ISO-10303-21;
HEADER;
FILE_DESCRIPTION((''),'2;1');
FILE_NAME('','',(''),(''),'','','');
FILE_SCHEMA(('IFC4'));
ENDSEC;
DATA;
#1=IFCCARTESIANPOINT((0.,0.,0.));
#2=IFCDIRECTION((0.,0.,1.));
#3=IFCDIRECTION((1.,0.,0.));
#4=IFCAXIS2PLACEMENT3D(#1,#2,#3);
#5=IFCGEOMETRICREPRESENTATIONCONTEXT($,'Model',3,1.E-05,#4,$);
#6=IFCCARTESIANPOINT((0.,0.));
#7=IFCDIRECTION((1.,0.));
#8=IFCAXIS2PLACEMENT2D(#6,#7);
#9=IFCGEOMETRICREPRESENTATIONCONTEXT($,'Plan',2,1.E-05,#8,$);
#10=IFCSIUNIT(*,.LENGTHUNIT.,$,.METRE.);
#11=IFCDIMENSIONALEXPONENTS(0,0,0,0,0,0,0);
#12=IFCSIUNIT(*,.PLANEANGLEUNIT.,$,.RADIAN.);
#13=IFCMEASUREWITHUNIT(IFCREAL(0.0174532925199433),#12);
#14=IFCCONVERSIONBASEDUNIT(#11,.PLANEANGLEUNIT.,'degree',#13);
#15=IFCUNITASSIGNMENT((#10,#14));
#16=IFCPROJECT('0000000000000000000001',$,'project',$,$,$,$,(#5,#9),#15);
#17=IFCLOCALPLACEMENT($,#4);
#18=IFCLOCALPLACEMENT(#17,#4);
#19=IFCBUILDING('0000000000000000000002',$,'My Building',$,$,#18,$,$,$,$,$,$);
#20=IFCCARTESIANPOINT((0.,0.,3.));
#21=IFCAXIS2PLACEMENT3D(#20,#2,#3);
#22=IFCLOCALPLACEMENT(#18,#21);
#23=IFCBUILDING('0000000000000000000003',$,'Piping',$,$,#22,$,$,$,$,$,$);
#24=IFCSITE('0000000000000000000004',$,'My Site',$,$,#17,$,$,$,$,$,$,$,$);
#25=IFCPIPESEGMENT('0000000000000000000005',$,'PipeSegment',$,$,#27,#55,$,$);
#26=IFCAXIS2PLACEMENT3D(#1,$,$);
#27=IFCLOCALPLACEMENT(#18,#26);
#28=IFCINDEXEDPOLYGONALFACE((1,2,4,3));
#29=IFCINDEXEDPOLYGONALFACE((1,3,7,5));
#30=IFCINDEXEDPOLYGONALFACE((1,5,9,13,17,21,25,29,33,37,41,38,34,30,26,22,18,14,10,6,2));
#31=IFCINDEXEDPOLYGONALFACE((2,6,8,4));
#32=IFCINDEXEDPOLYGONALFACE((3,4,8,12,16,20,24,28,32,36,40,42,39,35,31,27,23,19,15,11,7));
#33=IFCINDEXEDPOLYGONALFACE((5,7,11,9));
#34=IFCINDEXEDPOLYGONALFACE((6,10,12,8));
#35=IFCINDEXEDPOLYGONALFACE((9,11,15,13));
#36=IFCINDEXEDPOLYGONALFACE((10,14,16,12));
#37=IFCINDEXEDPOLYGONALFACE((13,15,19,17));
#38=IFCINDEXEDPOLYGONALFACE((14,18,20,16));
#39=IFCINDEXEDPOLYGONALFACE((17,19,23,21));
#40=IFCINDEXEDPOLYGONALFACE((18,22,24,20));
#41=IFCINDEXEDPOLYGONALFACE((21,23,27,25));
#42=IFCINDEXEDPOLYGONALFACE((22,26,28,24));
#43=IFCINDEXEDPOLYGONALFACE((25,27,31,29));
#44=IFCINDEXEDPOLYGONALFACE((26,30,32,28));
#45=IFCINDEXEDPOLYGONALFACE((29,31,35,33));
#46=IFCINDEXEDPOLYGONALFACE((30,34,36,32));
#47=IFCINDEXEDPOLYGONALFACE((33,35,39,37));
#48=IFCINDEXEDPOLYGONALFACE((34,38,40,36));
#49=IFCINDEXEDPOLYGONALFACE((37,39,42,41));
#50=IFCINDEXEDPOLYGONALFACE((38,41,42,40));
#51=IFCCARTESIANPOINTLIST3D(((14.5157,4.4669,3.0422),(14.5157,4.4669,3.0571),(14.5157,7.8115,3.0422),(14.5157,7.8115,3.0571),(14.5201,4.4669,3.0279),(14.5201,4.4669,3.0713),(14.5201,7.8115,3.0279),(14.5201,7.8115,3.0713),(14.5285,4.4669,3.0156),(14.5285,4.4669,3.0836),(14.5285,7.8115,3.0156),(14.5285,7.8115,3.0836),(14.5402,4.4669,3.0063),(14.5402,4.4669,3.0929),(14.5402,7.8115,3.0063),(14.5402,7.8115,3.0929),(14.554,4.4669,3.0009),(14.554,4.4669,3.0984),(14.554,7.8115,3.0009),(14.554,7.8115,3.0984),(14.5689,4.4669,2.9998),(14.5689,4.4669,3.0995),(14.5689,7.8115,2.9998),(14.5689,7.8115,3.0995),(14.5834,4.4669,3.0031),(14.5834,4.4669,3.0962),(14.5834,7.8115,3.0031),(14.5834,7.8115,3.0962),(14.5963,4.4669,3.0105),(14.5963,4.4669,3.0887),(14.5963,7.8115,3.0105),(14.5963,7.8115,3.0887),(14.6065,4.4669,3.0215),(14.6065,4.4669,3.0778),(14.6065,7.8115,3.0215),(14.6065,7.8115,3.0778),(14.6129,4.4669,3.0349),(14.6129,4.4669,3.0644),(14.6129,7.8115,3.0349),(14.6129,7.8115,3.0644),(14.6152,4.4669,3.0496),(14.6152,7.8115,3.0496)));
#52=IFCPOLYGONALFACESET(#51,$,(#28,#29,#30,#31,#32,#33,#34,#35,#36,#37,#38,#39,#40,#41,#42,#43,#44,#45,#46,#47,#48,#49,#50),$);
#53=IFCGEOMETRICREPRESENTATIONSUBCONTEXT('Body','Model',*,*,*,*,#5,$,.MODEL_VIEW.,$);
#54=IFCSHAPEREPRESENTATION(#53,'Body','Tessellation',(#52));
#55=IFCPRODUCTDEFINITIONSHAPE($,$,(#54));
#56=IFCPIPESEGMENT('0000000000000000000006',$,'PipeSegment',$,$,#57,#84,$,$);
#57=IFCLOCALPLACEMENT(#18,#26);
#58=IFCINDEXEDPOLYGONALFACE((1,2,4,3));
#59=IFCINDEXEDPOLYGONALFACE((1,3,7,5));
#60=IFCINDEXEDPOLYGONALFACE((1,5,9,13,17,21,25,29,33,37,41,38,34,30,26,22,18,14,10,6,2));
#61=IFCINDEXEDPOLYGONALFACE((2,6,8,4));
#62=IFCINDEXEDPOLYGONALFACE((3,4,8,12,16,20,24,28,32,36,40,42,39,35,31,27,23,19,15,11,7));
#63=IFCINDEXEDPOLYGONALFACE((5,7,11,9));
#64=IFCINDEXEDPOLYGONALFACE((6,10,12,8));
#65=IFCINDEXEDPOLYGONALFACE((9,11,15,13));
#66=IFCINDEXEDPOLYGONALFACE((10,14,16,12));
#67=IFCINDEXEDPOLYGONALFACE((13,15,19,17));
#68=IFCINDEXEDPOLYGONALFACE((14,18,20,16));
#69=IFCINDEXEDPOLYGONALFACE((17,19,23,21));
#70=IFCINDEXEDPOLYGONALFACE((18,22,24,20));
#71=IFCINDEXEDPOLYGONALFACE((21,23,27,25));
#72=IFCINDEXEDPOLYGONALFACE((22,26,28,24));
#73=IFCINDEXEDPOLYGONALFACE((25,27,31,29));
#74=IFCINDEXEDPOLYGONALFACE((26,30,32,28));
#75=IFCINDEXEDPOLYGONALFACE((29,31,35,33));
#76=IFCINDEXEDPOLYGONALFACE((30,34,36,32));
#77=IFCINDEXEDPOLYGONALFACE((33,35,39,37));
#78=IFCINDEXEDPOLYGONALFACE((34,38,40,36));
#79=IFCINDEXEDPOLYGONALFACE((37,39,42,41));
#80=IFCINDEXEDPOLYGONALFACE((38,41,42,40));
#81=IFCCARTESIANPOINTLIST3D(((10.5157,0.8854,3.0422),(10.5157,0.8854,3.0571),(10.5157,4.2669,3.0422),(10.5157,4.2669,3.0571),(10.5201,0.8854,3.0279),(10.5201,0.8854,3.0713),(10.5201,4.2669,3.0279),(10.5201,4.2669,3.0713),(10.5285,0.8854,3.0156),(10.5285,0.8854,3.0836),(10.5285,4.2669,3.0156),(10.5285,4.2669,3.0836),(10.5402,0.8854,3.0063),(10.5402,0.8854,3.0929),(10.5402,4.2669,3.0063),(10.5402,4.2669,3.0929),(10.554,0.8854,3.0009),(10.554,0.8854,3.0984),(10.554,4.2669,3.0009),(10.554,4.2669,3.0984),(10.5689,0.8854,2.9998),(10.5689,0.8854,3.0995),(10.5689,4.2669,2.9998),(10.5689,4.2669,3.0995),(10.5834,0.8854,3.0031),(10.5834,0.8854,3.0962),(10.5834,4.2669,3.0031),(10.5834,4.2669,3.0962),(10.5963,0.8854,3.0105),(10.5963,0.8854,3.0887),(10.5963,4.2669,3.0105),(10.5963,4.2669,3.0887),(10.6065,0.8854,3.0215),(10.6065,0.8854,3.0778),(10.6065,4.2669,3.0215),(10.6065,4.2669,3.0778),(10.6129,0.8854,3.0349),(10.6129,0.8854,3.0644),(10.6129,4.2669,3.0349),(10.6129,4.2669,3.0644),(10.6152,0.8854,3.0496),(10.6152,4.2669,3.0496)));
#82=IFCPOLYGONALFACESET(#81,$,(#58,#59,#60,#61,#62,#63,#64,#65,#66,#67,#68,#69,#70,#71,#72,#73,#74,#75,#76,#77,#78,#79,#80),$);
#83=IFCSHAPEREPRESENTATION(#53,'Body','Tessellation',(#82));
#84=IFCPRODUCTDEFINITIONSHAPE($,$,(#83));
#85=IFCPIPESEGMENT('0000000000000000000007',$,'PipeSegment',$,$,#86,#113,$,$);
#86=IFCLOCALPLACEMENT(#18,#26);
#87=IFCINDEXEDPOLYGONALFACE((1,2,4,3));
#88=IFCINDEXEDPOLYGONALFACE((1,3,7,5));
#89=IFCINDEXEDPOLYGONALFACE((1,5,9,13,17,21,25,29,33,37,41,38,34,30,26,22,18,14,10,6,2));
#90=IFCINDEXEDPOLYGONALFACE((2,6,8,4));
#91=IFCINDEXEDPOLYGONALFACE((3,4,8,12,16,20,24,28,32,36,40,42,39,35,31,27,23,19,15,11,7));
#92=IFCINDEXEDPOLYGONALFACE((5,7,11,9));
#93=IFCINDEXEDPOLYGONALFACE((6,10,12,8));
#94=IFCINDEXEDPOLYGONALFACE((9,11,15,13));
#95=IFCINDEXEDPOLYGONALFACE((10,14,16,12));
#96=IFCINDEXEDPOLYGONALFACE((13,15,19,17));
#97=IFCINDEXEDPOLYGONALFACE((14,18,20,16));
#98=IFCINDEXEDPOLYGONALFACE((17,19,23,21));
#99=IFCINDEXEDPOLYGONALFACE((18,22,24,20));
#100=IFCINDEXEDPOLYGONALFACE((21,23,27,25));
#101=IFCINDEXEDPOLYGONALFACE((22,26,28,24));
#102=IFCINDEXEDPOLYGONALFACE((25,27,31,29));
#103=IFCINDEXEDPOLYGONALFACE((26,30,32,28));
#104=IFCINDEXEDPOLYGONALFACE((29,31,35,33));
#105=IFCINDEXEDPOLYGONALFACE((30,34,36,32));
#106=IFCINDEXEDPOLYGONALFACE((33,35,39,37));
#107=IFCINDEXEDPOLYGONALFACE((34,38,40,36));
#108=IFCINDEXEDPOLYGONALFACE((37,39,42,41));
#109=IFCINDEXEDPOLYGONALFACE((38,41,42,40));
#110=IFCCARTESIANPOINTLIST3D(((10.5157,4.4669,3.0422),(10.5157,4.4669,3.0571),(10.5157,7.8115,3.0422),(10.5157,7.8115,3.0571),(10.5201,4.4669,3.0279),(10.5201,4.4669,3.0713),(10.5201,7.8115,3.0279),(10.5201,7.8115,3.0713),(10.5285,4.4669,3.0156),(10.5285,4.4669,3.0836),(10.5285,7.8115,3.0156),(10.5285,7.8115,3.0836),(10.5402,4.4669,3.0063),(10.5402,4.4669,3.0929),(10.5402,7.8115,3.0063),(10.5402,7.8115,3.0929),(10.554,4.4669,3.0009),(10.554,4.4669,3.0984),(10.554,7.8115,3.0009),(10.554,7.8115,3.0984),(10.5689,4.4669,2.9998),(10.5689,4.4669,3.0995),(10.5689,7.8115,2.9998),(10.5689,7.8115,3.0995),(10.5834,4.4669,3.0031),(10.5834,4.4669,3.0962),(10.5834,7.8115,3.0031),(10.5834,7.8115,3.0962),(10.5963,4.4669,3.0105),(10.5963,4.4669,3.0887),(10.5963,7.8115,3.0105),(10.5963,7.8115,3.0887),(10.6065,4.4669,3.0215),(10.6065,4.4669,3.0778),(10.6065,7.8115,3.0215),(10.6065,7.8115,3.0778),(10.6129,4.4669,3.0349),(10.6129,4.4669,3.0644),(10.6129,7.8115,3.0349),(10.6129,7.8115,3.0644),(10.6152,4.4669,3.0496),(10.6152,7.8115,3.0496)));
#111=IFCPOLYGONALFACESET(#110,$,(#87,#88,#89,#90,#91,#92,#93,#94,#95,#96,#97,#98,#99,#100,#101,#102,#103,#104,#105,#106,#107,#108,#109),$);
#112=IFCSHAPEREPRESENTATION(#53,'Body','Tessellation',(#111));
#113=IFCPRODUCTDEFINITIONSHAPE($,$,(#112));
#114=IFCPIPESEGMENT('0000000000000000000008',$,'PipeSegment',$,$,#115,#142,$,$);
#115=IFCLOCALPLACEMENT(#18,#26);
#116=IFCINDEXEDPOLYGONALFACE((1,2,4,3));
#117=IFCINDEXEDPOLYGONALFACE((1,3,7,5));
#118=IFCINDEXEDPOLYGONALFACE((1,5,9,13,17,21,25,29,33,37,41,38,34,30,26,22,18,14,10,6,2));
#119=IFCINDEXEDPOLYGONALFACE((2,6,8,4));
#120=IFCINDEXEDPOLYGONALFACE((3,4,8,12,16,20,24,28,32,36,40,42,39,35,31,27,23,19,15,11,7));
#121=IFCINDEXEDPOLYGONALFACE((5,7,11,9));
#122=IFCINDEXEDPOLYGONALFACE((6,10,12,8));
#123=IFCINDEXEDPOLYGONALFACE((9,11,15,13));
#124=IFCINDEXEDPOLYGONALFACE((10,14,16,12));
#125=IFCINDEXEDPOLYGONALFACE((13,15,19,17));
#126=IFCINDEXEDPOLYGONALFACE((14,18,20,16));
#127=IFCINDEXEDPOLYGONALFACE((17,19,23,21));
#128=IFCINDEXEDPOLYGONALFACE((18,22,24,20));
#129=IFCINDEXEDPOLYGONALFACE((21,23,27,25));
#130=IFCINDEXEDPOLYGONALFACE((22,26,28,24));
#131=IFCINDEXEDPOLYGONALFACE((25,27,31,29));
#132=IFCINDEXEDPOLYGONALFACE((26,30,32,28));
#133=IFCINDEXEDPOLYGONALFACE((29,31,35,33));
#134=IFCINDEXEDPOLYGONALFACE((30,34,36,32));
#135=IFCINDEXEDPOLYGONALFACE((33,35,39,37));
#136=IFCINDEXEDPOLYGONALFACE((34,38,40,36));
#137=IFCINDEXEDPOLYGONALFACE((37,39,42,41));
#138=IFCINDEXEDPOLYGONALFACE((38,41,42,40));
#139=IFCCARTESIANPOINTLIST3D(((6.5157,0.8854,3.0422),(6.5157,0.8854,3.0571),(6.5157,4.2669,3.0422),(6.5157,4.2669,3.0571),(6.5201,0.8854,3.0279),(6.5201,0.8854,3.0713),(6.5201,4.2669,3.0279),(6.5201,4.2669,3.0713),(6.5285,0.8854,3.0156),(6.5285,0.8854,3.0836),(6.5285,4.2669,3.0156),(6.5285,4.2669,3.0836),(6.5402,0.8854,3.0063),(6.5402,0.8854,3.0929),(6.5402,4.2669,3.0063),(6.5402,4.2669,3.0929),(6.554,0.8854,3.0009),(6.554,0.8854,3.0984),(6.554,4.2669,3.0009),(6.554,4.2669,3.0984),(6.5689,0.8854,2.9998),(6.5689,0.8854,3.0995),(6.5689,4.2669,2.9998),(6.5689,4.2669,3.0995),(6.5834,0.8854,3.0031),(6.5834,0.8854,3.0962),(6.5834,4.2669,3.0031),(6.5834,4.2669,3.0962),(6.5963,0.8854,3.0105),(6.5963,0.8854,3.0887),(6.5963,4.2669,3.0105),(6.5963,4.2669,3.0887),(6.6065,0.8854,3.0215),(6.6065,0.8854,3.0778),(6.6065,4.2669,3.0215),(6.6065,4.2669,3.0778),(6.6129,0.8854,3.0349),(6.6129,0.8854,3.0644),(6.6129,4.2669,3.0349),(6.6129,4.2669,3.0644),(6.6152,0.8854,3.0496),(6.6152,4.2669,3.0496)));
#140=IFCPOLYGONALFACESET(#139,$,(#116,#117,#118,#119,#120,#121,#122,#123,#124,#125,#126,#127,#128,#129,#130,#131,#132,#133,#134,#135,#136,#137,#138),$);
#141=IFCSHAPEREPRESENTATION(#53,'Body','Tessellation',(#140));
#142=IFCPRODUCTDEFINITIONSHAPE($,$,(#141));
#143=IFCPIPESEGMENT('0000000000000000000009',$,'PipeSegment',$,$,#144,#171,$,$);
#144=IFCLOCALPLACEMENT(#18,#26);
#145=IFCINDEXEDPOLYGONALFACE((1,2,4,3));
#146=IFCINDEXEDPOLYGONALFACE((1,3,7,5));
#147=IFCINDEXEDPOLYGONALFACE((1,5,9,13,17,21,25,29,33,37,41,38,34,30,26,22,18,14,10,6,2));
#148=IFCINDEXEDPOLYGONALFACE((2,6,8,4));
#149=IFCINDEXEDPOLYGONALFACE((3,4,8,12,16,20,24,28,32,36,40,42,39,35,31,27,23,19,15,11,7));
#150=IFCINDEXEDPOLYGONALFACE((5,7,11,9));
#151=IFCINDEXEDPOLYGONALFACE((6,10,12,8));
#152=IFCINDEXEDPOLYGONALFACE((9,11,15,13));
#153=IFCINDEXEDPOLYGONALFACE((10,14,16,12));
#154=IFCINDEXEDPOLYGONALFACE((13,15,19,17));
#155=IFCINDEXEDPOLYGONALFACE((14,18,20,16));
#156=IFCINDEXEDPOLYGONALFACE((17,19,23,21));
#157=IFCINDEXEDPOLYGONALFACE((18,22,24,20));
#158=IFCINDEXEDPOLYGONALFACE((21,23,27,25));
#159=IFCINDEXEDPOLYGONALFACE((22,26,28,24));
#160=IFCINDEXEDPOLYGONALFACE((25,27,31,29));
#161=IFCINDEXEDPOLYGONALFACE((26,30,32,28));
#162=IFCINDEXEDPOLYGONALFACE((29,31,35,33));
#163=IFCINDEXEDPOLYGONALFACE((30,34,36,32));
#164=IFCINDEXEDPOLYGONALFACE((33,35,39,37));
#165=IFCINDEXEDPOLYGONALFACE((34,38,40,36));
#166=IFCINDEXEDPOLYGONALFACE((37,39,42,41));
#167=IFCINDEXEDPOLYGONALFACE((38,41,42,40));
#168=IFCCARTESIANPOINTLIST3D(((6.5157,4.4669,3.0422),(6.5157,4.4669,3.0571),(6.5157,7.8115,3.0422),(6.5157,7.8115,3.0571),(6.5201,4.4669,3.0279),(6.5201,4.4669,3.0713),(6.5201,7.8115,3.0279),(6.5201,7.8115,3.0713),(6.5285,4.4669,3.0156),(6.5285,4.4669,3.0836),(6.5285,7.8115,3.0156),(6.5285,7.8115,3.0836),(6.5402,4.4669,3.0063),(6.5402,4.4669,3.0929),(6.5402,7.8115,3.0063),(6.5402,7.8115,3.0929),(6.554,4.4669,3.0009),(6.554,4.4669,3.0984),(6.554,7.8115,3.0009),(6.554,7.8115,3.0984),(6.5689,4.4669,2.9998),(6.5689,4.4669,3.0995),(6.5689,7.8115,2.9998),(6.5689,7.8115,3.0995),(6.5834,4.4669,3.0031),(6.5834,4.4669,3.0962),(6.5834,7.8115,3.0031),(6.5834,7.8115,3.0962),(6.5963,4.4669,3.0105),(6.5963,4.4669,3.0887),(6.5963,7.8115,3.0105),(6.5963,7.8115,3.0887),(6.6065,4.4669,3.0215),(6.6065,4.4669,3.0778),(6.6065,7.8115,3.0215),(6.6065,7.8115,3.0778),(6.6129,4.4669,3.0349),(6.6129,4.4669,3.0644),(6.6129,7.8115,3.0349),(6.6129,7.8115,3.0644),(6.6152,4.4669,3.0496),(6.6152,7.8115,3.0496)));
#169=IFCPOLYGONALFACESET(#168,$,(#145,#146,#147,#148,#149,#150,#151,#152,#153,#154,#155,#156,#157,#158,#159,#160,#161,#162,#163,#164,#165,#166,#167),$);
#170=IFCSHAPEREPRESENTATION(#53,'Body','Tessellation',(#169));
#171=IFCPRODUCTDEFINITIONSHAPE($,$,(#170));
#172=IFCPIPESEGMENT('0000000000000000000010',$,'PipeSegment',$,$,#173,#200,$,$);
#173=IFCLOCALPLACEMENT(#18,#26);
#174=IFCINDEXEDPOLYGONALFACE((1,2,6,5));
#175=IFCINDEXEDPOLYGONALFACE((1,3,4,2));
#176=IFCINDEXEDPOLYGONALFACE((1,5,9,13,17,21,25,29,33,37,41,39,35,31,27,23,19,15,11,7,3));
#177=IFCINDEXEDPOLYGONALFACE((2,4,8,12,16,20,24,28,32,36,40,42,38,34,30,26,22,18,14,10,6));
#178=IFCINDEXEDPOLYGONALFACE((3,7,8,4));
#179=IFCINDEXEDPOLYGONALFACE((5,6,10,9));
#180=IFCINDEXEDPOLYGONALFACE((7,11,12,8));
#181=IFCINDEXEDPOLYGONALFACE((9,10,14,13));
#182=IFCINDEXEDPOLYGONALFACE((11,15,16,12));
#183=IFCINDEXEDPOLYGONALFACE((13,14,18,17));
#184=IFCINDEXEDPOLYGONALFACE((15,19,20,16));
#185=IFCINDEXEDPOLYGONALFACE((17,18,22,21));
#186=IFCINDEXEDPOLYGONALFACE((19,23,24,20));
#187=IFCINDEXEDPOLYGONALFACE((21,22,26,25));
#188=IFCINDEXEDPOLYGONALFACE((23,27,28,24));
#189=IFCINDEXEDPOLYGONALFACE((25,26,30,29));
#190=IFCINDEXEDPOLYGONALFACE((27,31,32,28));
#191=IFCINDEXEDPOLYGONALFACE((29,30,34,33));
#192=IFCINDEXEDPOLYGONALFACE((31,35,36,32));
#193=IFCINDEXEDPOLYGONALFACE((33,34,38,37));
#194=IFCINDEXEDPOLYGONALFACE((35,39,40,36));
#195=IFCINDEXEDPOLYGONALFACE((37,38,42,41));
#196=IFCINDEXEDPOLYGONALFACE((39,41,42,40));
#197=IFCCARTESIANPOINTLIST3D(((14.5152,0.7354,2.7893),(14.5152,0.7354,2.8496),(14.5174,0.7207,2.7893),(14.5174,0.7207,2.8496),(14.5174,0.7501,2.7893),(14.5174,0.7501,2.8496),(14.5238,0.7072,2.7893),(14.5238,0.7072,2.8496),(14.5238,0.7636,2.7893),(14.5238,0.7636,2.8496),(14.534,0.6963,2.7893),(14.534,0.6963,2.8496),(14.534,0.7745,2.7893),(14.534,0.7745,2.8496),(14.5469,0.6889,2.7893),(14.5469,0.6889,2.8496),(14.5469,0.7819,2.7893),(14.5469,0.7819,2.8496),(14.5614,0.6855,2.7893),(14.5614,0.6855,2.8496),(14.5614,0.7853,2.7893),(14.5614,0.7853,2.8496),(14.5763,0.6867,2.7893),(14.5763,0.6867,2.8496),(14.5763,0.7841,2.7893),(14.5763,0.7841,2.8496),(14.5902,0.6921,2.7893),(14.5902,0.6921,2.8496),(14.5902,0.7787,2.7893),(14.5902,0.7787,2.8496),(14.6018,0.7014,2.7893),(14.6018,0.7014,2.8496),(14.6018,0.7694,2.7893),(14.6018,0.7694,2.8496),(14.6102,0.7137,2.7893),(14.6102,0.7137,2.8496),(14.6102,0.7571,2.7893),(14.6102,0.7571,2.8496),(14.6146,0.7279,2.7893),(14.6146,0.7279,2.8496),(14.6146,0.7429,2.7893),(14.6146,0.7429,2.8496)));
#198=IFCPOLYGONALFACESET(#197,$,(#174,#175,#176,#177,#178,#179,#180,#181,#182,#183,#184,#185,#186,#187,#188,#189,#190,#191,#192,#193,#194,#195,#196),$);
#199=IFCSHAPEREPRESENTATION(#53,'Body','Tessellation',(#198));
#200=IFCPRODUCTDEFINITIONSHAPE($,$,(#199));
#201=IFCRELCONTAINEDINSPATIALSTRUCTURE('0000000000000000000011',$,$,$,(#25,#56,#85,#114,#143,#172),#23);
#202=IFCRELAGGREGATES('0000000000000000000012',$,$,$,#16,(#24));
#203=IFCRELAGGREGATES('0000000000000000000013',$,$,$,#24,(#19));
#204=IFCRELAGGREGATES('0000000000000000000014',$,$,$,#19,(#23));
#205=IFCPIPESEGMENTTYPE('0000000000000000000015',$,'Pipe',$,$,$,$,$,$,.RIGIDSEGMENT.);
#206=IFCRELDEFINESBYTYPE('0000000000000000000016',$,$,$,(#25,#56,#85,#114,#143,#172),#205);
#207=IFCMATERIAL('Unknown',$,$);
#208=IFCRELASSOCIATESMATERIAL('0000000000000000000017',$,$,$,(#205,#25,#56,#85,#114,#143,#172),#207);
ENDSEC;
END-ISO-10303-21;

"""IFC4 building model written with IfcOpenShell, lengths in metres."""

from ifc_helpers import new_model, entity, si_unit, converted_unit, frame, origin_with_axes, origin_2d_with_axis, place, context, subcontext, project, spatial, circle, extrude, material, material_profile, profile_set, profile_usage, type_object, element, save


model = new_model("IFC4")

# Units and contexts
model_context = context("Model", 3, precision=1e-05, world=origin_with_axes())
plan_context = context("Plan", 2, precision=1e-05, world=origin_2d_with_axis())
body_context = subcontext(model_context, "Body", "Model", "MODEL_VIEW")
ifc_project = project(units=[si_unit("LENGTHUNIT", "METRE"), converted_unit("PLANEANGLEUNIT", "degree", entity("IfcReal", 0.0174532925199433), si_unit("PLANEANGLEUNIT", "RADIAN"), dimensions=[0, 0, 0, 0, 0, 0, 0])], contexts=[model_context, plan_context])

# Site, buildings
site_placement = place(None, origin_with_axes())
site = spatial("IfcSite", under=ifc_project, at=site_placement, Name="My Site")
building_1_placement = place(site_placement, origin_with_axes())
building_1 = spatial("IfcBuilding", under=site, at=building_1_placement, Name="My Building")
building_2_placement = place(building_1_placement, frame((0.0, 0.0, 3.0), z_axis=(0.0, 0.0, 1.0), x_axis=(1.0, 0.0, 0.0)))
building_2 = spatial("IfcBuilding", under=building_1, at=building_2_placement, Name="Piping")

# Pipe segments
ifc_material = material(Name="Unknown")
ifc_material_profile_1 = material_profile(ifc_material, circle(Radius=0.05))
ifc_profile_set_1 = profile_set([ifc_material_profile_1])
pipe_segment_type = type_object("IfcPipeSegmentType", Name="Pipe", PredefinedType="RIGIDSEGMENT", material=ifc_profile_set_1)
ifc_profile_usage_1 = profile_usage(ifc_profile_set_1, cardinal=5)
pipe_segment_1_placement = place(building_2_placement, frame((14.5652, 4.4669, 0.0496), z_axis=(0.0, 1.0, 0.0), x_axis=(1.0, 0.0, 0.0)))
element("IfcPipeSegment", 1, at=pipe_segment_1_placement, inside=building_2, type_object=pipe_segment_type, material=ifc_profile_usage_1, Name="PipeSegment", context=body_context, shape_type="SweptSolid", body=[
    extrude(circle(Radius=0.05), origin_with_axes(), (0.0, 0.0, 1.0), 3.3446),
])
ifc_profile_usage_2 = profile_usage(ifc_profile_set_1, cardinal=5)
pipe_segment_2_placement = place(building_2_placement, frame((10.5652, 0.8854, 0.0496), z_axis=(0.0, 1.0, 0.000001), x_axis=(1.0, 0.0, 0.0)))
element("IfcPipeSegment", 2, at=pipe_segment_2_placement, inside=building_2, type_object=pipe_segment_type, material=ifc_profile_usage_2, Name="PipeSegment", context=body_context, shape_type="SweptSolid", body=[
    extrude(circle(Radius=0.05), origin_with_axes(), (0.0, 0.0, 1.0), 3.3815),
])
ifc_profile_usage_3 = profile_usage(ifc_profile_set_1, cardinal=5)
pipe_segment_3_placement = place(building_2_placement, frame((10.5652, 4.4669, 0.0496), z_axis=(0.0, 1.0, 0.0), x_axis=(1.0, 0.0, 0.0)))
element("IfcPipeSegment", 3, at=pipe_segment_3_placement, inside=building_2, type_object=pipe_segment_type, material=ifc_profile_usage_3, Name="PipeSegment", context=body_context, shape_type="SweptSolid", body=[
    extrude(circle(Radius=0.05), origin_with_axes(), (0.0, 0.0, 1.0), 3.3446),
])
ifc_profile_usage_4 = profile_usage(ifc_profile_set_1, cardinal=5)
pipe_segment_4_placement = place(building_2_placement, frame((6.5652, 0.8854, 0.0496), z_axis=(0.0, 1.0, 0.000001), x_axis=(1.0, 0.0, 0.0)))
element("IfcPipeSegment", 4, at=pipe_segment_4_placement, inside=building_2, type_object=pipe_segment_type, material=ifc_profile_usage_4, Name="PipeSegment", context=body_context, shape_type="SweptSolid", body=[
    extrude(circle(Radius=0.05), origin_with_axes(), (0.0, 0.0, 1.0), 3.3815),
])
ifc_profile_usage_5 = profile_usage(ifc_profile_set_1, cardinal=5)
pipe_segment_5_placement = place(building_2_placement, frame((6.5652, 4.4669, 0.0496), z_axis=(0.0, 1.0, 0.0), x_axis=(1.0, 0.0, 0.0)))
element("IfcPipeSegment", 5, at=pipe_segment_5_placement, inside=building_2, type_object=pipe_segment_type, material=ifc_profile_usage_5, Name="PipeSegment", context=body_context, shape_type="SweptSolid", body=[
    extrude(circle(Radius=0.05), origin_with_axes(), (0.0, 0.0, 1.0), 3.3446),
])
ifc_profile_usage_6 = profile_usage(ifc_profile_set_1, cardinal=5)
pipe_segment_6_placement = place(building_2_placement, frame((14.5652, 0.7354, -0.1504), z_axis=(0.0, 0.0, -1.0), x_axis=(-1.0, 0.0, 0.0)))
element("IfcPipeSegment", 6, at=pipe_segment_6_placement, inside=building_2, type_object=pipe_segment_type, material=ifc_profile_usage_6, Name="PipeSegment", context=body_context, shape_type="SweptSolid", body=[
    extrude(circle(Radius=0.05), origin_with_axes(), (0.0, 0.0, 1.0), 0.0604),
])

save(model, "model.ifc")
